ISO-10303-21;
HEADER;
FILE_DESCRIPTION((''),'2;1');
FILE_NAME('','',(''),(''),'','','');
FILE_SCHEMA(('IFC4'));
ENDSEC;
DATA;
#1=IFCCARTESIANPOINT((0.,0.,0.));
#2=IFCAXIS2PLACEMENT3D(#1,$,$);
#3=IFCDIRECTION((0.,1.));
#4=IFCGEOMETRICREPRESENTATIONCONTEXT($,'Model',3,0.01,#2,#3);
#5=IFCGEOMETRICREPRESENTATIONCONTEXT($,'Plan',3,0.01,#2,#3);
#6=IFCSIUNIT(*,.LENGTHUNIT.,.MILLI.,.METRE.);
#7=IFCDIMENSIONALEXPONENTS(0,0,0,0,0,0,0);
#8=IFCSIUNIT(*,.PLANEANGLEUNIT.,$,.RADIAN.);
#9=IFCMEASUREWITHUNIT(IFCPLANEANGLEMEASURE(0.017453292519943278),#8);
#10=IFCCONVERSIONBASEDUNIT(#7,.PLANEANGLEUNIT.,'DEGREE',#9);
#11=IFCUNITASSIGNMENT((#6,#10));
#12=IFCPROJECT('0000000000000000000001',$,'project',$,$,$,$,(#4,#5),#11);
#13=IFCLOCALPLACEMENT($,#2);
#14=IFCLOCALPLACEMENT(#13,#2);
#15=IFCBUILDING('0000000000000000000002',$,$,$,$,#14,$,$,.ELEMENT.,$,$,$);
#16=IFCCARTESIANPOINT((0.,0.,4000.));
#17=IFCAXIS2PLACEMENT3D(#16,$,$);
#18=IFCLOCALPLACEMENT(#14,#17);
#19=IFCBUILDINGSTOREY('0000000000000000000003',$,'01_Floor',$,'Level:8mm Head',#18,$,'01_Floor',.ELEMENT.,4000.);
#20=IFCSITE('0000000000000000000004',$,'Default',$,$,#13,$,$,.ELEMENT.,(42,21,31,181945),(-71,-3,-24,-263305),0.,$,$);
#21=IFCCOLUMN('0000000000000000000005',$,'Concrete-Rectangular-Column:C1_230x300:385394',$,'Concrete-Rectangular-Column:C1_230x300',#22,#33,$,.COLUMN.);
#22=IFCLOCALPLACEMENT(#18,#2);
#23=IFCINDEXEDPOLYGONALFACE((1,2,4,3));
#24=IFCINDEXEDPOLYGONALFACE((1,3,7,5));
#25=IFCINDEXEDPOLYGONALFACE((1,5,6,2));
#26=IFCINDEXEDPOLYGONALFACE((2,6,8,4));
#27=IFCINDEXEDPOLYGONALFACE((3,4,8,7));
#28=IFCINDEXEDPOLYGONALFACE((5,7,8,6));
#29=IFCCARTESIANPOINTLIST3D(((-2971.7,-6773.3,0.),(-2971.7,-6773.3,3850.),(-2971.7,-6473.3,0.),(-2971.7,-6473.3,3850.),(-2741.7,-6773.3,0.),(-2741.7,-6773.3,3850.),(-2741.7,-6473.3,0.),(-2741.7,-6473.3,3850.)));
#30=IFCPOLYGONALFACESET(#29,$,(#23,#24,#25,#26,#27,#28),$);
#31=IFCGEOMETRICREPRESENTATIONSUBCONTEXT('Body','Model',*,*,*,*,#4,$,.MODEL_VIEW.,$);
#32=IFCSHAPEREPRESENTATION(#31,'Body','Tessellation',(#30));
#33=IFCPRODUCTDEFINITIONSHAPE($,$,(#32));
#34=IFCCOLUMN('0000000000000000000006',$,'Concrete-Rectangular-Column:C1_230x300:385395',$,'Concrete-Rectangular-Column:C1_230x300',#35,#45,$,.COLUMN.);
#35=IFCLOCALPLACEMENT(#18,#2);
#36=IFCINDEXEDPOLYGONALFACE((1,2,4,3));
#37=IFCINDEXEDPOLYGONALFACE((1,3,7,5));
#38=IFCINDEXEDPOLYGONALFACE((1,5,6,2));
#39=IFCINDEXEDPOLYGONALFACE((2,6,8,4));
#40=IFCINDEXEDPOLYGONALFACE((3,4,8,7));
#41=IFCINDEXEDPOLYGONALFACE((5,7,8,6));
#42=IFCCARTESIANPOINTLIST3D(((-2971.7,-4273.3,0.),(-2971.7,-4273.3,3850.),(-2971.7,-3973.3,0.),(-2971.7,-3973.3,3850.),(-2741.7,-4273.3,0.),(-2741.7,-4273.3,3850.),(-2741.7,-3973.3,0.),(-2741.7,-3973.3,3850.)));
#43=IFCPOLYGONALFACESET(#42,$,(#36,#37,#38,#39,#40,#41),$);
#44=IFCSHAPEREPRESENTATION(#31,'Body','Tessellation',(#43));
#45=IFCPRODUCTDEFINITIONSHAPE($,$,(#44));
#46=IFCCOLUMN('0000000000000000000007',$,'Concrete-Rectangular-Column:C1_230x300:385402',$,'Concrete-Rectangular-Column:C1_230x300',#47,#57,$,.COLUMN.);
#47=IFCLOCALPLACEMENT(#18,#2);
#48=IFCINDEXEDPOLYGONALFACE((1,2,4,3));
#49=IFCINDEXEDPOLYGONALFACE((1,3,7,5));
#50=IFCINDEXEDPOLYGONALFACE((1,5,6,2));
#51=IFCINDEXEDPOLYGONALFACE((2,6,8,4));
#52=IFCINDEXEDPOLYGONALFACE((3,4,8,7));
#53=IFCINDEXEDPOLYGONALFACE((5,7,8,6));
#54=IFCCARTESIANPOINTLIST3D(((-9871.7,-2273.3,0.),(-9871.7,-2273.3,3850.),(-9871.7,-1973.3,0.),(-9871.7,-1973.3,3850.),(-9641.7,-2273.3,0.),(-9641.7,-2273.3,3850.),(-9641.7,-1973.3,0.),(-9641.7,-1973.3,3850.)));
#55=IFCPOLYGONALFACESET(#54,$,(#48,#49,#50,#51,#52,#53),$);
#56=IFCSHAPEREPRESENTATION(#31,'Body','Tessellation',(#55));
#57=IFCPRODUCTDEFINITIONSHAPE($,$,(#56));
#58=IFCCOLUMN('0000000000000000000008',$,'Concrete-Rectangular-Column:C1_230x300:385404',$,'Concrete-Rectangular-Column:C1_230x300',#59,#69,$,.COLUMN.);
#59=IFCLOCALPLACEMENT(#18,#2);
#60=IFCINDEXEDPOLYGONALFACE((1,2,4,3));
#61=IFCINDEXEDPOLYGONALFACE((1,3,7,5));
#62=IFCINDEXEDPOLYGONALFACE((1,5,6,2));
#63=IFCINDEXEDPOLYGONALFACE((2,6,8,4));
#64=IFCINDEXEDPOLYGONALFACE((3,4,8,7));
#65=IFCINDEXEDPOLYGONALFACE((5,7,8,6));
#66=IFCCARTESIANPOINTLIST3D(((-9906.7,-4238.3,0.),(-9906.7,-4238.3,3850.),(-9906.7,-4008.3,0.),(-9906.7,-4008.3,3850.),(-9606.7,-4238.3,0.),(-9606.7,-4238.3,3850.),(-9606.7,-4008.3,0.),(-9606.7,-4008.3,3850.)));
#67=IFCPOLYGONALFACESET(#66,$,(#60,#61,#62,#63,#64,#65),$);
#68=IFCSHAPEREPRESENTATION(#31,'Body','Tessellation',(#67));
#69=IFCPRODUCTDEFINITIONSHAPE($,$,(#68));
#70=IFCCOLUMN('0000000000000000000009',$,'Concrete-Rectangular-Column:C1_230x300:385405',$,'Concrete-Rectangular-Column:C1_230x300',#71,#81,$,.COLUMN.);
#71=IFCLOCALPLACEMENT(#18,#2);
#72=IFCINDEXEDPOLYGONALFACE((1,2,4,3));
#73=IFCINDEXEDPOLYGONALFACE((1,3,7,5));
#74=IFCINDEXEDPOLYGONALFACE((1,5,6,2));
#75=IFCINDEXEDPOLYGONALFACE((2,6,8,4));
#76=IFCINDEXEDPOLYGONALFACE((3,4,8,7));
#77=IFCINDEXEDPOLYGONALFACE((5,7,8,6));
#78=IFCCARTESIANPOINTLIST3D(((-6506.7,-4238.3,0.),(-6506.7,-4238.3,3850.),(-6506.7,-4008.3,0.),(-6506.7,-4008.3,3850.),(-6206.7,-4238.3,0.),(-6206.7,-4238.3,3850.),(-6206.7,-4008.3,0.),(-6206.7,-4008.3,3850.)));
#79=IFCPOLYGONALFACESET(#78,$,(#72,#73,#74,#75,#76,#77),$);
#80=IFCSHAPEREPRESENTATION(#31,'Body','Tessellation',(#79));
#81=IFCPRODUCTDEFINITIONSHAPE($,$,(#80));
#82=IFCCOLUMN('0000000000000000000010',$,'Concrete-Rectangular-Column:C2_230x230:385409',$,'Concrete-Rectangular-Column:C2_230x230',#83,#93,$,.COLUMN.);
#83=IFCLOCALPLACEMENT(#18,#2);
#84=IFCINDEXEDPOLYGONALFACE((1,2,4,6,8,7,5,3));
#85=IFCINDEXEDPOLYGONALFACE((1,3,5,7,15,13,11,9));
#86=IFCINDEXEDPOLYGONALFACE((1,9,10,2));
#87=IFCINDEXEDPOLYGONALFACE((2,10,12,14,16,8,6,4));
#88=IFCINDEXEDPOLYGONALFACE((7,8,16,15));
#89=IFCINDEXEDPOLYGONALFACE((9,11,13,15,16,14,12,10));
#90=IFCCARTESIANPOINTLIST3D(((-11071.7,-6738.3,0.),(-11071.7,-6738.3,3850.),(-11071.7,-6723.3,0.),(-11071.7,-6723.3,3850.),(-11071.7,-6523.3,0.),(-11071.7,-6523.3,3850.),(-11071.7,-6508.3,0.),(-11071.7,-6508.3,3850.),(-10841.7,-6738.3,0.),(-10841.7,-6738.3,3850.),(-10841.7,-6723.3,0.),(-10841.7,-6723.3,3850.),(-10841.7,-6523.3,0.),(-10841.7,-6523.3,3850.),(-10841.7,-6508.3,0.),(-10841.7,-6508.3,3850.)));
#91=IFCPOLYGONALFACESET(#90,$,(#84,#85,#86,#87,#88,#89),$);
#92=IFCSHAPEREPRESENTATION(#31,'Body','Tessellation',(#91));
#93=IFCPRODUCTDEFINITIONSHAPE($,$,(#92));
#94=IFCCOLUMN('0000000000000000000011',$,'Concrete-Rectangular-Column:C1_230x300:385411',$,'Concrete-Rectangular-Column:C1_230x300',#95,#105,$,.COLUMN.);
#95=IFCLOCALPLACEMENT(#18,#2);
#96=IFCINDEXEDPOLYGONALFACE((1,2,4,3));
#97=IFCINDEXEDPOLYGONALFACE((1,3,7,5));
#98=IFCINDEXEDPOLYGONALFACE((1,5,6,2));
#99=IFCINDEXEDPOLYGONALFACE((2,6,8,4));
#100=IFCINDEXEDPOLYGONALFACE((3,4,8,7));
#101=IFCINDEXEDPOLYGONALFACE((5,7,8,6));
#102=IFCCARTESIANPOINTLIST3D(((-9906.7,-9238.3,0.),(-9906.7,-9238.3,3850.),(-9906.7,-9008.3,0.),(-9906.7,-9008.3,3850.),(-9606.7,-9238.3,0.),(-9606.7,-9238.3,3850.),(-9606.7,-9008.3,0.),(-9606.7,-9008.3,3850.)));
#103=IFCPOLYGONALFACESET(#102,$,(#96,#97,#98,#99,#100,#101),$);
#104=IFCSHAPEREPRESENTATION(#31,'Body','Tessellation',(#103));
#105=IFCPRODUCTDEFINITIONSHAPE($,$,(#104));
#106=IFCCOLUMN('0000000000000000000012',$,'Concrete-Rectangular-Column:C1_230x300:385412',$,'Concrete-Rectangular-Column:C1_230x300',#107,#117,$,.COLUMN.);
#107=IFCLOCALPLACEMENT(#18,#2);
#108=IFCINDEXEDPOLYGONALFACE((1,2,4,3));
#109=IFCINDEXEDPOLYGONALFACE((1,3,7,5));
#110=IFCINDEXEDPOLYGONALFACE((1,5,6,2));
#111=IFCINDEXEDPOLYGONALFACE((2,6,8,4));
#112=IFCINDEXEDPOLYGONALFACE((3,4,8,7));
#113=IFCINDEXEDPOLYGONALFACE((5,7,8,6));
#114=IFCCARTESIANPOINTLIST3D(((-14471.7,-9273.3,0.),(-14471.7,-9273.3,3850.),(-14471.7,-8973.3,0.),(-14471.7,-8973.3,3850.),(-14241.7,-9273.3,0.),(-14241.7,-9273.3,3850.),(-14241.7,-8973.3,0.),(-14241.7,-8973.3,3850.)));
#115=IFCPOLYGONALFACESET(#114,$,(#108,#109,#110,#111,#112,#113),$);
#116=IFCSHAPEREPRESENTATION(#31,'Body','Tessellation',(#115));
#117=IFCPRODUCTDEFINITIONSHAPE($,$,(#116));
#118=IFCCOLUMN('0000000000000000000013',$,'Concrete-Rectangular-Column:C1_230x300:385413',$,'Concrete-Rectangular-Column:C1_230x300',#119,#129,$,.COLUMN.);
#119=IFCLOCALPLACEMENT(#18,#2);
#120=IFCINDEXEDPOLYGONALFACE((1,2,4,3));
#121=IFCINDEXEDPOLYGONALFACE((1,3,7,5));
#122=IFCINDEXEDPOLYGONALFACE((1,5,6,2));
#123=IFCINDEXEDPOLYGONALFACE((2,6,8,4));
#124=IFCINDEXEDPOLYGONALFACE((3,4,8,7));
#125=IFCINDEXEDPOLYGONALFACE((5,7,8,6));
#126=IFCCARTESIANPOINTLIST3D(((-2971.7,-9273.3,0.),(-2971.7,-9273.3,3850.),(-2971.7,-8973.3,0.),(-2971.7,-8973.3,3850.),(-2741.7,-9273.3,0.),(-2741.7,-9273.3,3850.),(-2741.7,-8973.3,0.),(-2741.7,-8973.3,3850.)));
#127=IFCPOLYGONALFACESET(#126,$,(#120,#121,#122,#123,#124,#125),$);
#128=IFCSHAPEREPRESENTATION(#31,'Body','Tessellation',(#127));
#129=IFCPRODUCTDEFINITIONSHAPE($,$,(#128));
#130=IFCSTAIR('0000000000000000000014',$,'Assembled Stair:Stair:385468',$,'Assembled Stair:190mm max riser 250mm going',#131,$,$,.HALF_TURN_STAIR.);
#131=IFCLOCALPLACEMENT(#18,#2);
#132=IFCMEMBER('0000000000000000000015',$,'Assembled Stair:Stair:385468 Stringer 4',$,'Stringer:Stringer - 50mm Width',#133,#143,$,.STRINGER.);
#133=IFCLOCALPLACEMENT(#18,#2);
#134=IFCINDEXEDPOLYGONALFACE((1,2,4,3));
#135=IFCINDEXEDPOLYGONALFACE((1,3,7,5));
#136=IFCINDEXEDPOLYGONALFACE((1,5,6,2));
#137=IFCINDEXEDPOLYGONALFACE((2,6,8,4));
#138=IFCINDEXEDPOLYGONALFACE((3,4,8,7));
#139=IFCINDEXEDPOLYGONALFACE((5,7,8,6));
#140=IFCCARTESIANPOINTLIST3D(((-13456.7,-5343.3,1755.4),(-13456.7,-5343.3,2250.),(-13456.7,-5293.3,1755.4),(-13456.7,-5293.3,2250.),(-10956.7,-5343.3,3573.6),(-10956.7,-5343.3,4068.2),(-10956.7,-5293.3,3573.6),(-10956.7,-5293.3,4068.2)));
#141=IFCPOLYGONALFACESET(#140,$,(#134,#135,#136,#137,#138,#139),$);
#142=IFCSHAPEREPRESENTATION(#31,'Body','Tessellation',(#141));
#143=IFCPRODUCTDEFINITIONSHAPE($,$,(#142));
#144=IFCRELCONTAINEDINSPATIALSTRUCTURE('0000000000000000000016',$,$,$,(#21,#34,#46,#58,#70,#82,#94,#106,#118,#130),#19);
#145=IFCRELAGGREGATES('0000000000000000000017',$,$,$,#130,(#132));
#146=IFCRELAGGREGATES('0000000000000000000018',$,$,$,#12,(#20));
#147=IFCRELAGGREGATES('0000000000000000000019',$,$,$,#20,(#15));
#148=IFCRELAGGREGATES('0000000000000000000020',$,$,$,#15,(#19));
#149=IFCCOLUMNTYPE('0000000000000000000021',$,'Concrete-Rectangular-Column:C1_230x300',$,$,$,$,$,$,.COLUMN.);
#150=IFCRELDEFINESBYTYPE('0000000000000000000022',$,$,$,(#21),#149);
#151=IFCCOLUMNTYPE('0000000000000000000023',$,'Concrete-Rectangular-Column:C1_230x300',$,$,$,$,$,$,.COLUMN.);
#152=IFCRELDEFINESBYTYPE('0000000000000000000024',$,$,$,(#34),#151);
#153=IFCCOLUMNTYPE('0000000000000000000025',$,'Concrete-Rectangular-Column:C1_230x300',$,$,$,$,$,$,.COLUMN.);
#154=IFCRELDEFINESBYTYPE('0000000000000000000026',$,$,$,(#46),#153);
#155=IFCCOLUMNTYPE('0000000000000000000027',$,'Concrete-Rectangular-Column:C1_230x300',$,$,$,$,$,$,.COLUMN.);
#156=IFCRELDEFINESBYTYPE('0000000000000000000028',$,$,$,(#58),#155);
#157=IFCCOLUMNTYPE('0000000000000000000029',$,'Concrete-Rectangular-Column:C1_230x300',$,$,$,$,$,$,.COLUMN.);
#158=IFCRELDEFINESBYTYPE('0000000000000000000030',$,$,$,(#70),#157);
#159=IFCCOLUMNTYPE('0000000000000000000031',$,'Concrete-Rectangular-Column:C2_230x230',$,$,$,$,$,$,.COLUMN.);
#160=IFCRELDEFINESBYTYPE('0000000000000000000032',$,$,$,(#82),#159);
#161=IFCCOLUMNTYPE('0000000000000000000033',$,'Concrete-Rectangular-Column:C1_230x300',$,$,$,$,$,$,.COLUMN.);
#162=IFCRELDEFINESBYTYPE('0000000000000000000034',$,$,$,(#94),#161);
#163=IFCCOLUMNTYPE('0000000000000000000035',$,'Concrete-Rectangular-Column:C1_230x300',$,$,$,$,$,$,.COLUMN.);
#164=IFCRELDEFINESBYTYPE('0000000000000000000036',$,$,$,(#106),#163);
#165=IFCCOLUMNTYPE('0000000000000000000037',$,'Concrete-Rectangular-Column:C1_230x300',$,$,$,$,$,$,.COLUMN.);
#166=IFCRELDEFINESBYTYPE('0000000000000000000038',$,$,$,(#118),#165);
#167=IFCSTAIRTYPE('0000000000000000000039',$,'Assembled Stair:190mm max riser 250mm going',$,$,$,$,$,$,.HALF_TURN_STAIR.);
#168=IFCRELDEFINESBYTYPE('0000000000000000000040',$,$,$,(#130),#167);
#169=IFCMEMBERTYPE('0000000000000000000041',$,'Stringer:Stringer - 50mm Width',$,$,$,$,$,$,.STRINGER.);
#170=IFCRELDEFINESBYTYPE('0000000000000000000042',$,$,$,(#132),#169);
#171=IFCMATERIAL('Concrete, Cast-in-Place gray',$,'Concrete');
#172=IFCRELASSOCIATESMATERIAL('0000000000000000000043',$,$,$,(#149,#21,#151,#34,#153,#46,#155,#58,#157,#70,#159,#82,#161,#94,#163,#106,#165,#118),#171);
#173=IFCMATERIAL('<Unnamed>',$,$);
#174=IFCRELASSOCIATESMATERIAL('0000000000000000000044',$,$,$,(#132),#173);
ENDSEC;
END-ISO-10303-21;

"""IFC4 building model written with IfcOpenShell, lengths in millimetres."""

from ifc_helpers import new_model, entity, si_unit, converted_unit, direction, frame, origin, place, context, subcontext, project, spatial, indexed_curve, outline, extrude, source, transform, mapped, material, type_object, type_shapes, element, aggregate, save


model = new_model("IFC4")

# Units and contexts
model_context = context("Model", 3, precision=0.01, world=origin(), true_north=direction((0.0, 1.0)))
plan_context = context("Plan", 3, precision=0.01, world=origin(), true_north=direction((0.0, 1.0)))
body_context = subcontext(model_context, "Body", "Model", "MODEL_VIEW")
ifc_project = project(units=[si_unit("LENGTHUNIT", "METRE", prefix="MILLI"), converted_unit("PLANEANGLEUNIT", "DEGREE", entity("IfcPlaneAngleMeasure", 0.017453292519943278), si_unit("PLANEANGLEUNIT", "RADIAN"), dimensions=[0, 0, 0, 0, 0, 0, 0])], contexts=[model_context, plan_context])

# Site, building, storey
site_placement = place(None, origin())
site = spatial("IfcSite", under=ifc_project, at=site_placement, Name="Default", CompositionType="ELEMENT", RefLatitude=(42, 21, 31, 181945), RefLongitude=(-71, -3, -24, -263305), RefElevation=0.0)
building_placement = place(site_placement, origin())
building = spatial("IfcBuilding", under=site, at=building_placement, CompositionType="ELEMENT")
storey_placement = place(building_placement, frame((0.0, 0.0, 4000.0)))
storey = spatial("IfcBuildingStorey", under=building, at=storey_placement, Name="01_Floor", ObjectType="Level:8mm Head", LongName="01_Floor", CompositionType="ELEMENT", Elevation=4000.0)

# Columns
ifc_material_1 = material(Name="Concrete, Cast-in-Place gray", Category="Concrete")
column_type_1 = type_object("IfcColumnType", Name="Concrete-Rectangular-Column:C1_230x300", PredefinedType="COLUMN", material=ifc_material_1)
shared_shape_1 = source(origin(), body_context, "Body", "SweptSolid", [
    extrude(outline(indexed_curve([(-115.0, -150.0), (115.0, -150.0), (115.0, 150.0), (-115.0, 150.0), (-115.0, -150.0)], self_intersect=False)), frame((-2856.7, -6623.3, 4000.0), z_axis=(0.0, 0.0, 1.0), x_axis=(-1.0, 0.0, 0.0)), (0.0, 0.0, 1.0), 3850.0),
])
type_shapes(column_type_1, [shared_shape_1])
column_1_placement = place(storey_placement, frame((0.0, 0.0, -4000.0)))
element("IfcColumn", 1, at=column_1_placement, inside=storey, type_object=column_type_1, material=ifc_material_1, Name="Concrete-Rectangular-Column:C1_230x300:385394", ObjectType="Concrete-Rectangular-Column:C1_230x300", PredefinedType="COLUMN", context=body_context, shape_type="MappedRepresentation", body=[
    mapped(shared_shape_1, transform((0.0, 0.0, 0.0), scale=1.0)),
])
column_type_2 = type_object("IfcColumnType", Name="Concrete-Rectangular-Column:C1_230x300", PredefinedType="COLUMN", material=ifc_material_1)
shared_shape_2 = source(origin(), body_context, "Body", "SweptSolid", [
    extrude(outline(indexed_curve([(-115.0, -150.0), (115.0, -150.0), (115.0, 150.0), (-115.0, 150.0), (-115.0, -150.0)], self_intersect=False)), frame((-2856.7, -4123.3, 4000.0)), (0.0, 0.0, 1.0), 3850.0),
])
type_shapes(column_type_2, [shared_shape_2])
column_2_placement = place(storey_placement, frame((0.0, 0.0, -4000.0)))
element("IfcColumn", 2, at=column_2_placement, inside=storey, type_object=column_type_2, material=ifc_material_1, Name="Concrete-Rectangular-Column:C1_230x300:385395", ObjectType="Concrete-Rectangular-Column:C1_230x300", PredefinedType="COLUMN", context=body_context, shape_type="MappedRepresentation", body=[
    mapped(shared_shape_2, transform((0.0, 0.0, 0.0), scale=1.0)),
])
column_type_3 = type_object("IfcColumnType", Name="Concrete-Rectangular-Column:C1_230x300", PredefinedType="COLUMN", material=ifc_material_1)
shared_shape_3 = source(origin(), body_context, "Body", "SweptSolid", [
    extrude(outline(indexed_curve([(-115.0, -150.0), (115.0, -150.0), (115.0, 150.0), (-115.0, 150.0), (-115.0, -150.0)], self_intersect=False)), frame((-9756.7, -2123.3, 4000.0)), (0.0, 0.0, 1.0), 3850.0),
])
type_shapes(column_type_3, [shared_shape_3])
column_3_placement = place(storey_placement, frame((0.0, 0.0, -4000.0)))
element("IfcColumn", 3, at=column_3_placement, inside=storey, type_object=column_type_3, material=ifc_material_1, Name="Concrete-Rectangular-Column:C1_230x300:385402", ObjectType="Concrete-Rectangular-Column:C1_230x300", PredefinedType="COLUMN", context=body_context, shape_type="MappedRepresentation", body=[
    mapped(shared_shape_3, transform((0.0, 0.0, 0.0), scale=1.0)),
])
column_type_4 = type_object("IfcColumnType", Name="Concrete-Rectangular-Column:C1_230x300", PredefinedType="COLUMN", material=ifc_material_1)
shared_shape_4 = source(origin(), body_context, "Body", "SweptSolid", [
    extrude(outline(indexed_curve([(-1925.0, -115.0), (1925.0, -115.0), (1925.0, 115.0), (-1925.0, 115.0), (-1925.0, -115.0)], self_intersect=False)), frame((-9906.7, -4123.3, 5925.0), z_axis=(1.0, 0.0, 0.0), x_axis=(0.0, 0.0, 1.0)), (0.0, 0.0, 1.0), 300.0),
])
type_shapes(column_type_4, [shared_shape_4])
column_4_placement = place(storey_placement, frame((0.0, 0.0, -4000.0)))
element("IfcColumn", 4, at=column_4_placement, inside=storey, type_object=column_type_4, material=ifc_material_1, Name="Concrete-Rectangular-Column:C1_230x300:385404", ObjectType="Concrete-Rectangular-Column:C1_230x300", PredefinedType="COLUMN", context=body_context, shape_type="MappedRepresentation", body=[
    mapped(shared_shape_4, transform((0.0, 0.0, 0.0), scale=1.0)),
])
column_type_5 = type_object("IfcColumnType", Name="Concrete-Rectangular-Column:C1_230x300", PredefinedType="COLUMN", material=ifc_material_1)
shared_shape_5 = source(origin(), body_context, "Body", "SweptSolid", [
    extrude(outline(indexed_curve([(-1925.0, -115.0), (1925.0, -115.0), (1925.0, 115.0), (-1925.0, 115.0), (-1925.0, -115.0)], self_intersect=False)), frame((-6506.7, -4123.3, 5925.0), z_axis=(1.0, 0.0, 0.0), x_axis=(0.0, 0.0, 1.0)), (0.0, 0.0, 1.0), 300.0),
])
type_shapes(column_type_5, [shared_shape_5])
column_5_placement = place(storey_placement, frame((0.0, 0.0, -4000.0)))
element("IfcColumn", 5, at=column_5_placement, inside=storey, type_object=column_type_5, material=ifc_material_1, Name="Concrete-Rectangular-Column:C1_230x300:385405", ObjectType="Concrete-Rectangular-Column:C1_230x300", PredefinedType="COLUMN", context=body_context, shape_type="MappedRepresentation", body=[
    mapped(shared_shape_5, transform((0.0, 0.0, 0.0), scale=1.0)),
])
column_type_6 = type_object("IfcColumnType", Name="Concrete-Rectangular-Column:C2_230x230", PredefinedType="COLUMN", material=ifc_material_1)
shared_shape_6 = source(origin(), body_context, "Body", "SweptSolid", [
    extrude(outline(indexed_curve([(-115.0, -115.0), (-100.0, -115.0), (100.0, -115.0), (115.0, -115.0), (115.0, 115.0), (100.0, 115.0), (-100.0, 115.0), (-115.0, 115.0), (-115.0, -115.0)], self_intersect=False)), frame((-10956.7, -6623.3, 4000.0), z_axis=(0.0, 0.0, 1.0), x_axis=(0.0, -1.0, 0.0)), (0.0, 0.0, 1.0), 3850.0),
])
type_shapes(column_type_6, [shared_shape_6])
column_6_placement = place(storey_placement, frame((0.0, 0.0, -4000.0)))
element("IfcColumn", 6, at=column_6_placement, inside=storey, type_object=column_type_6, material=ifc_material_1, Name="Concrete-Rectangular-Column:C2_230x230:385409", ObjectType="Concrete-Rectangular-Column:C2_230x230", PredefinedType="COLUMN", context=body_context, shape_type="MappedRepresentation", body=[
    mapped(shared_shape_6, transform((0.0, 0.0, 0.0), scale=1.0)),
])
column_type_7 = type_object("IfcColumnType", Name="Concrete-Rectangular-Column:C1_230x300", PredefinedType="COLUMN", material=ifc_material_1)
shared_shape_7 = source(origin(), body_context, "Body", "SweptSolid", [
    extrude(outline(indexed_curve([(-1925.0, -115.0), (1925.0, -115.0), (1925.0, 115.0), (-1925.0, 115.0), (-1925.0, -115.0)], self_intersect=False)), frame((-9906.7, -9123.3, 5925.0), z_axis=(1.0, 0.0, 0.0), x_axis=(0.0, 0.0, 1.0)), (0.0, 0.0, 1.0), 300.0),
])
type_shapes(column_type_7, [shared_shape_7])
column_7_placement = place(storey_placement, frame((0.0, 0.0, -4000.0)))
element("IfcColumn", 7, at=column_7_placement, inside=storey, type_object=column_type_7, material=ifc_material_1, Name="Concrete-Rectangular-Column:C1_230x300:385411", ObjectType="Concrete-Rectangular-Column:C1_230x300", PredefinedType="COLUMN", context=body_context, shape_type="MappedRepresentation", body=[
    mapped(shared_shape_7, transform((0.0, 0.0, 0.0), scale=1.0)),
])
column_type_8 = type_object("IfcColumnType", Name="Concrete-Rectangular-Column:C1_230x300", PredefinedType="COLUMN", material=ifc_material_1)
shared_shape_8 = source(origin(), body_context, "Body", "SweptSolid", [
    extrude(outline(indexed_curve([(-115.0, -150.0), (115.0, -150.0), (115.0, 150.0), (-115.0, 150.0), (-115.0, -150.0)], self_intersect=False)), frame((-14356.7, -9123.3, 4000.0), z_axis=(0.0, 0.0, 1.0), x_axis=(-1.0, 0.0, 0.0)), (0.0, 0.0, 1.0), 3850.0),
])
type_shapes(column_type_8, [shared_shape_8])
column_8_placement = place(storey_placement, frame((0.0, 0.0, -4000.0)))
element("IfcColumn", 8, at=column_8_placement, inside=storey, type_object=column_type_8, material=ifc_material_1, Name="Concrete-Rectangular-Column:C1_230x300:385412", ObjectType="Concrete-Rectangular-Column:C1_230x300", PredefinedType="COLUMN", context=body_context, shape_type="MappedRepresentation", body=[
    mapped(shared_shape_8, transform((0.0, 0.0, 0.0), scale=1.0)),
])
column_type_9 = type_object("IfcColumnType", Name="Concrete-Rectangular-Column:C1_230x300", PredefinedType="COLUMN", material=ifc_material_1)
shared_shape_9 = source(origin(), body_context, "Body", "SweptSolid", [
    extrude(outline(indexed_curve([(-115.0, -150.0), (115.0, -150.0), (115.0, 150.0), (-115.0, 150.0), (-115.0, -150.0)], self_intersect=False)), frame((-2856.7, -9123.3, 4000.0), z_axis=(0.0, 0.0, 1.0), x_axis=(-1.0, 0.0, 0.0)), (0.0, 0.0, 1.0), 3850.0),
])
type_shapes(column_type_9, [shared_shape_9])
column_9_placement = place(storey_placement, frame((0.0, 0.0, -4000.0)))
element("IfcColumn", 9, at=column_9_placement, inside=storey, type_object=column_type_9, material=ifc_material_1, Name="Concrete-Rectangular-Column:C1_230x300:385413", ObjectType="Concrete-Rectangular-Column:C1_230x300", PredefinedType="COLUMN", context=body_context, shape_type="MappedRepresentation", body=[
    mapped(shared_shape_9, transform((0.0, 0.0, 0.0), scale=1.0)),
])

# Stair, member
stair_type = type_object("IfcStairType", Name="Assembled Stair:190mm max riser 250mm going", PredefinedType="HALF_TURN_STAIR")
stair_placement = place(storey_placement, origin())
stair = element("IfcStair", 10, at=stair_placement, inside=storey, type_object=stair_type, Name="Assembled Stair:Stair:385468", ObjectType="Assembled Stair:190mm max riser 250mm going", PredefinedType="HALF_TURN_STAIR")
ifc_material_2 = material(Name="<Unnamed>")
member_type = type_object("IfcMemberType", Name="Stringer:Stringer - 50mm Width", PredefinedType="STRINGER")
member_1_placement = place(stair_placement, origin())
member_1 = element("IfcMember", 11, at=member_1_placement, type_object=member_type, material=ifc_material_2, Name="Assembled Stair:Stair:385468 Stringer 4", ObjectType="Stringer:Stringer - 50mm Width", PredefinedType="STRINGER", context=body_context, shape_type="SweptSolid", body=[
    extrude(outline(indexed_curve([(-1400.2, -200.0), (1691.1, -200.0), (1400.2, 200.0), (-1691.1, 200.0), (-1400.2, -200.0)], self_intersect=False)), frame((-12206.7, -5343.3, 2911.8), z_axis=(0.0, 1.0, 0.0), x_axis=(0.808736, 0.0, 0.588172)), (0.0, 0.0, 1.0), 50.0),
])

aggregate(stair, [member_1])

save(model, "model.ifc")
